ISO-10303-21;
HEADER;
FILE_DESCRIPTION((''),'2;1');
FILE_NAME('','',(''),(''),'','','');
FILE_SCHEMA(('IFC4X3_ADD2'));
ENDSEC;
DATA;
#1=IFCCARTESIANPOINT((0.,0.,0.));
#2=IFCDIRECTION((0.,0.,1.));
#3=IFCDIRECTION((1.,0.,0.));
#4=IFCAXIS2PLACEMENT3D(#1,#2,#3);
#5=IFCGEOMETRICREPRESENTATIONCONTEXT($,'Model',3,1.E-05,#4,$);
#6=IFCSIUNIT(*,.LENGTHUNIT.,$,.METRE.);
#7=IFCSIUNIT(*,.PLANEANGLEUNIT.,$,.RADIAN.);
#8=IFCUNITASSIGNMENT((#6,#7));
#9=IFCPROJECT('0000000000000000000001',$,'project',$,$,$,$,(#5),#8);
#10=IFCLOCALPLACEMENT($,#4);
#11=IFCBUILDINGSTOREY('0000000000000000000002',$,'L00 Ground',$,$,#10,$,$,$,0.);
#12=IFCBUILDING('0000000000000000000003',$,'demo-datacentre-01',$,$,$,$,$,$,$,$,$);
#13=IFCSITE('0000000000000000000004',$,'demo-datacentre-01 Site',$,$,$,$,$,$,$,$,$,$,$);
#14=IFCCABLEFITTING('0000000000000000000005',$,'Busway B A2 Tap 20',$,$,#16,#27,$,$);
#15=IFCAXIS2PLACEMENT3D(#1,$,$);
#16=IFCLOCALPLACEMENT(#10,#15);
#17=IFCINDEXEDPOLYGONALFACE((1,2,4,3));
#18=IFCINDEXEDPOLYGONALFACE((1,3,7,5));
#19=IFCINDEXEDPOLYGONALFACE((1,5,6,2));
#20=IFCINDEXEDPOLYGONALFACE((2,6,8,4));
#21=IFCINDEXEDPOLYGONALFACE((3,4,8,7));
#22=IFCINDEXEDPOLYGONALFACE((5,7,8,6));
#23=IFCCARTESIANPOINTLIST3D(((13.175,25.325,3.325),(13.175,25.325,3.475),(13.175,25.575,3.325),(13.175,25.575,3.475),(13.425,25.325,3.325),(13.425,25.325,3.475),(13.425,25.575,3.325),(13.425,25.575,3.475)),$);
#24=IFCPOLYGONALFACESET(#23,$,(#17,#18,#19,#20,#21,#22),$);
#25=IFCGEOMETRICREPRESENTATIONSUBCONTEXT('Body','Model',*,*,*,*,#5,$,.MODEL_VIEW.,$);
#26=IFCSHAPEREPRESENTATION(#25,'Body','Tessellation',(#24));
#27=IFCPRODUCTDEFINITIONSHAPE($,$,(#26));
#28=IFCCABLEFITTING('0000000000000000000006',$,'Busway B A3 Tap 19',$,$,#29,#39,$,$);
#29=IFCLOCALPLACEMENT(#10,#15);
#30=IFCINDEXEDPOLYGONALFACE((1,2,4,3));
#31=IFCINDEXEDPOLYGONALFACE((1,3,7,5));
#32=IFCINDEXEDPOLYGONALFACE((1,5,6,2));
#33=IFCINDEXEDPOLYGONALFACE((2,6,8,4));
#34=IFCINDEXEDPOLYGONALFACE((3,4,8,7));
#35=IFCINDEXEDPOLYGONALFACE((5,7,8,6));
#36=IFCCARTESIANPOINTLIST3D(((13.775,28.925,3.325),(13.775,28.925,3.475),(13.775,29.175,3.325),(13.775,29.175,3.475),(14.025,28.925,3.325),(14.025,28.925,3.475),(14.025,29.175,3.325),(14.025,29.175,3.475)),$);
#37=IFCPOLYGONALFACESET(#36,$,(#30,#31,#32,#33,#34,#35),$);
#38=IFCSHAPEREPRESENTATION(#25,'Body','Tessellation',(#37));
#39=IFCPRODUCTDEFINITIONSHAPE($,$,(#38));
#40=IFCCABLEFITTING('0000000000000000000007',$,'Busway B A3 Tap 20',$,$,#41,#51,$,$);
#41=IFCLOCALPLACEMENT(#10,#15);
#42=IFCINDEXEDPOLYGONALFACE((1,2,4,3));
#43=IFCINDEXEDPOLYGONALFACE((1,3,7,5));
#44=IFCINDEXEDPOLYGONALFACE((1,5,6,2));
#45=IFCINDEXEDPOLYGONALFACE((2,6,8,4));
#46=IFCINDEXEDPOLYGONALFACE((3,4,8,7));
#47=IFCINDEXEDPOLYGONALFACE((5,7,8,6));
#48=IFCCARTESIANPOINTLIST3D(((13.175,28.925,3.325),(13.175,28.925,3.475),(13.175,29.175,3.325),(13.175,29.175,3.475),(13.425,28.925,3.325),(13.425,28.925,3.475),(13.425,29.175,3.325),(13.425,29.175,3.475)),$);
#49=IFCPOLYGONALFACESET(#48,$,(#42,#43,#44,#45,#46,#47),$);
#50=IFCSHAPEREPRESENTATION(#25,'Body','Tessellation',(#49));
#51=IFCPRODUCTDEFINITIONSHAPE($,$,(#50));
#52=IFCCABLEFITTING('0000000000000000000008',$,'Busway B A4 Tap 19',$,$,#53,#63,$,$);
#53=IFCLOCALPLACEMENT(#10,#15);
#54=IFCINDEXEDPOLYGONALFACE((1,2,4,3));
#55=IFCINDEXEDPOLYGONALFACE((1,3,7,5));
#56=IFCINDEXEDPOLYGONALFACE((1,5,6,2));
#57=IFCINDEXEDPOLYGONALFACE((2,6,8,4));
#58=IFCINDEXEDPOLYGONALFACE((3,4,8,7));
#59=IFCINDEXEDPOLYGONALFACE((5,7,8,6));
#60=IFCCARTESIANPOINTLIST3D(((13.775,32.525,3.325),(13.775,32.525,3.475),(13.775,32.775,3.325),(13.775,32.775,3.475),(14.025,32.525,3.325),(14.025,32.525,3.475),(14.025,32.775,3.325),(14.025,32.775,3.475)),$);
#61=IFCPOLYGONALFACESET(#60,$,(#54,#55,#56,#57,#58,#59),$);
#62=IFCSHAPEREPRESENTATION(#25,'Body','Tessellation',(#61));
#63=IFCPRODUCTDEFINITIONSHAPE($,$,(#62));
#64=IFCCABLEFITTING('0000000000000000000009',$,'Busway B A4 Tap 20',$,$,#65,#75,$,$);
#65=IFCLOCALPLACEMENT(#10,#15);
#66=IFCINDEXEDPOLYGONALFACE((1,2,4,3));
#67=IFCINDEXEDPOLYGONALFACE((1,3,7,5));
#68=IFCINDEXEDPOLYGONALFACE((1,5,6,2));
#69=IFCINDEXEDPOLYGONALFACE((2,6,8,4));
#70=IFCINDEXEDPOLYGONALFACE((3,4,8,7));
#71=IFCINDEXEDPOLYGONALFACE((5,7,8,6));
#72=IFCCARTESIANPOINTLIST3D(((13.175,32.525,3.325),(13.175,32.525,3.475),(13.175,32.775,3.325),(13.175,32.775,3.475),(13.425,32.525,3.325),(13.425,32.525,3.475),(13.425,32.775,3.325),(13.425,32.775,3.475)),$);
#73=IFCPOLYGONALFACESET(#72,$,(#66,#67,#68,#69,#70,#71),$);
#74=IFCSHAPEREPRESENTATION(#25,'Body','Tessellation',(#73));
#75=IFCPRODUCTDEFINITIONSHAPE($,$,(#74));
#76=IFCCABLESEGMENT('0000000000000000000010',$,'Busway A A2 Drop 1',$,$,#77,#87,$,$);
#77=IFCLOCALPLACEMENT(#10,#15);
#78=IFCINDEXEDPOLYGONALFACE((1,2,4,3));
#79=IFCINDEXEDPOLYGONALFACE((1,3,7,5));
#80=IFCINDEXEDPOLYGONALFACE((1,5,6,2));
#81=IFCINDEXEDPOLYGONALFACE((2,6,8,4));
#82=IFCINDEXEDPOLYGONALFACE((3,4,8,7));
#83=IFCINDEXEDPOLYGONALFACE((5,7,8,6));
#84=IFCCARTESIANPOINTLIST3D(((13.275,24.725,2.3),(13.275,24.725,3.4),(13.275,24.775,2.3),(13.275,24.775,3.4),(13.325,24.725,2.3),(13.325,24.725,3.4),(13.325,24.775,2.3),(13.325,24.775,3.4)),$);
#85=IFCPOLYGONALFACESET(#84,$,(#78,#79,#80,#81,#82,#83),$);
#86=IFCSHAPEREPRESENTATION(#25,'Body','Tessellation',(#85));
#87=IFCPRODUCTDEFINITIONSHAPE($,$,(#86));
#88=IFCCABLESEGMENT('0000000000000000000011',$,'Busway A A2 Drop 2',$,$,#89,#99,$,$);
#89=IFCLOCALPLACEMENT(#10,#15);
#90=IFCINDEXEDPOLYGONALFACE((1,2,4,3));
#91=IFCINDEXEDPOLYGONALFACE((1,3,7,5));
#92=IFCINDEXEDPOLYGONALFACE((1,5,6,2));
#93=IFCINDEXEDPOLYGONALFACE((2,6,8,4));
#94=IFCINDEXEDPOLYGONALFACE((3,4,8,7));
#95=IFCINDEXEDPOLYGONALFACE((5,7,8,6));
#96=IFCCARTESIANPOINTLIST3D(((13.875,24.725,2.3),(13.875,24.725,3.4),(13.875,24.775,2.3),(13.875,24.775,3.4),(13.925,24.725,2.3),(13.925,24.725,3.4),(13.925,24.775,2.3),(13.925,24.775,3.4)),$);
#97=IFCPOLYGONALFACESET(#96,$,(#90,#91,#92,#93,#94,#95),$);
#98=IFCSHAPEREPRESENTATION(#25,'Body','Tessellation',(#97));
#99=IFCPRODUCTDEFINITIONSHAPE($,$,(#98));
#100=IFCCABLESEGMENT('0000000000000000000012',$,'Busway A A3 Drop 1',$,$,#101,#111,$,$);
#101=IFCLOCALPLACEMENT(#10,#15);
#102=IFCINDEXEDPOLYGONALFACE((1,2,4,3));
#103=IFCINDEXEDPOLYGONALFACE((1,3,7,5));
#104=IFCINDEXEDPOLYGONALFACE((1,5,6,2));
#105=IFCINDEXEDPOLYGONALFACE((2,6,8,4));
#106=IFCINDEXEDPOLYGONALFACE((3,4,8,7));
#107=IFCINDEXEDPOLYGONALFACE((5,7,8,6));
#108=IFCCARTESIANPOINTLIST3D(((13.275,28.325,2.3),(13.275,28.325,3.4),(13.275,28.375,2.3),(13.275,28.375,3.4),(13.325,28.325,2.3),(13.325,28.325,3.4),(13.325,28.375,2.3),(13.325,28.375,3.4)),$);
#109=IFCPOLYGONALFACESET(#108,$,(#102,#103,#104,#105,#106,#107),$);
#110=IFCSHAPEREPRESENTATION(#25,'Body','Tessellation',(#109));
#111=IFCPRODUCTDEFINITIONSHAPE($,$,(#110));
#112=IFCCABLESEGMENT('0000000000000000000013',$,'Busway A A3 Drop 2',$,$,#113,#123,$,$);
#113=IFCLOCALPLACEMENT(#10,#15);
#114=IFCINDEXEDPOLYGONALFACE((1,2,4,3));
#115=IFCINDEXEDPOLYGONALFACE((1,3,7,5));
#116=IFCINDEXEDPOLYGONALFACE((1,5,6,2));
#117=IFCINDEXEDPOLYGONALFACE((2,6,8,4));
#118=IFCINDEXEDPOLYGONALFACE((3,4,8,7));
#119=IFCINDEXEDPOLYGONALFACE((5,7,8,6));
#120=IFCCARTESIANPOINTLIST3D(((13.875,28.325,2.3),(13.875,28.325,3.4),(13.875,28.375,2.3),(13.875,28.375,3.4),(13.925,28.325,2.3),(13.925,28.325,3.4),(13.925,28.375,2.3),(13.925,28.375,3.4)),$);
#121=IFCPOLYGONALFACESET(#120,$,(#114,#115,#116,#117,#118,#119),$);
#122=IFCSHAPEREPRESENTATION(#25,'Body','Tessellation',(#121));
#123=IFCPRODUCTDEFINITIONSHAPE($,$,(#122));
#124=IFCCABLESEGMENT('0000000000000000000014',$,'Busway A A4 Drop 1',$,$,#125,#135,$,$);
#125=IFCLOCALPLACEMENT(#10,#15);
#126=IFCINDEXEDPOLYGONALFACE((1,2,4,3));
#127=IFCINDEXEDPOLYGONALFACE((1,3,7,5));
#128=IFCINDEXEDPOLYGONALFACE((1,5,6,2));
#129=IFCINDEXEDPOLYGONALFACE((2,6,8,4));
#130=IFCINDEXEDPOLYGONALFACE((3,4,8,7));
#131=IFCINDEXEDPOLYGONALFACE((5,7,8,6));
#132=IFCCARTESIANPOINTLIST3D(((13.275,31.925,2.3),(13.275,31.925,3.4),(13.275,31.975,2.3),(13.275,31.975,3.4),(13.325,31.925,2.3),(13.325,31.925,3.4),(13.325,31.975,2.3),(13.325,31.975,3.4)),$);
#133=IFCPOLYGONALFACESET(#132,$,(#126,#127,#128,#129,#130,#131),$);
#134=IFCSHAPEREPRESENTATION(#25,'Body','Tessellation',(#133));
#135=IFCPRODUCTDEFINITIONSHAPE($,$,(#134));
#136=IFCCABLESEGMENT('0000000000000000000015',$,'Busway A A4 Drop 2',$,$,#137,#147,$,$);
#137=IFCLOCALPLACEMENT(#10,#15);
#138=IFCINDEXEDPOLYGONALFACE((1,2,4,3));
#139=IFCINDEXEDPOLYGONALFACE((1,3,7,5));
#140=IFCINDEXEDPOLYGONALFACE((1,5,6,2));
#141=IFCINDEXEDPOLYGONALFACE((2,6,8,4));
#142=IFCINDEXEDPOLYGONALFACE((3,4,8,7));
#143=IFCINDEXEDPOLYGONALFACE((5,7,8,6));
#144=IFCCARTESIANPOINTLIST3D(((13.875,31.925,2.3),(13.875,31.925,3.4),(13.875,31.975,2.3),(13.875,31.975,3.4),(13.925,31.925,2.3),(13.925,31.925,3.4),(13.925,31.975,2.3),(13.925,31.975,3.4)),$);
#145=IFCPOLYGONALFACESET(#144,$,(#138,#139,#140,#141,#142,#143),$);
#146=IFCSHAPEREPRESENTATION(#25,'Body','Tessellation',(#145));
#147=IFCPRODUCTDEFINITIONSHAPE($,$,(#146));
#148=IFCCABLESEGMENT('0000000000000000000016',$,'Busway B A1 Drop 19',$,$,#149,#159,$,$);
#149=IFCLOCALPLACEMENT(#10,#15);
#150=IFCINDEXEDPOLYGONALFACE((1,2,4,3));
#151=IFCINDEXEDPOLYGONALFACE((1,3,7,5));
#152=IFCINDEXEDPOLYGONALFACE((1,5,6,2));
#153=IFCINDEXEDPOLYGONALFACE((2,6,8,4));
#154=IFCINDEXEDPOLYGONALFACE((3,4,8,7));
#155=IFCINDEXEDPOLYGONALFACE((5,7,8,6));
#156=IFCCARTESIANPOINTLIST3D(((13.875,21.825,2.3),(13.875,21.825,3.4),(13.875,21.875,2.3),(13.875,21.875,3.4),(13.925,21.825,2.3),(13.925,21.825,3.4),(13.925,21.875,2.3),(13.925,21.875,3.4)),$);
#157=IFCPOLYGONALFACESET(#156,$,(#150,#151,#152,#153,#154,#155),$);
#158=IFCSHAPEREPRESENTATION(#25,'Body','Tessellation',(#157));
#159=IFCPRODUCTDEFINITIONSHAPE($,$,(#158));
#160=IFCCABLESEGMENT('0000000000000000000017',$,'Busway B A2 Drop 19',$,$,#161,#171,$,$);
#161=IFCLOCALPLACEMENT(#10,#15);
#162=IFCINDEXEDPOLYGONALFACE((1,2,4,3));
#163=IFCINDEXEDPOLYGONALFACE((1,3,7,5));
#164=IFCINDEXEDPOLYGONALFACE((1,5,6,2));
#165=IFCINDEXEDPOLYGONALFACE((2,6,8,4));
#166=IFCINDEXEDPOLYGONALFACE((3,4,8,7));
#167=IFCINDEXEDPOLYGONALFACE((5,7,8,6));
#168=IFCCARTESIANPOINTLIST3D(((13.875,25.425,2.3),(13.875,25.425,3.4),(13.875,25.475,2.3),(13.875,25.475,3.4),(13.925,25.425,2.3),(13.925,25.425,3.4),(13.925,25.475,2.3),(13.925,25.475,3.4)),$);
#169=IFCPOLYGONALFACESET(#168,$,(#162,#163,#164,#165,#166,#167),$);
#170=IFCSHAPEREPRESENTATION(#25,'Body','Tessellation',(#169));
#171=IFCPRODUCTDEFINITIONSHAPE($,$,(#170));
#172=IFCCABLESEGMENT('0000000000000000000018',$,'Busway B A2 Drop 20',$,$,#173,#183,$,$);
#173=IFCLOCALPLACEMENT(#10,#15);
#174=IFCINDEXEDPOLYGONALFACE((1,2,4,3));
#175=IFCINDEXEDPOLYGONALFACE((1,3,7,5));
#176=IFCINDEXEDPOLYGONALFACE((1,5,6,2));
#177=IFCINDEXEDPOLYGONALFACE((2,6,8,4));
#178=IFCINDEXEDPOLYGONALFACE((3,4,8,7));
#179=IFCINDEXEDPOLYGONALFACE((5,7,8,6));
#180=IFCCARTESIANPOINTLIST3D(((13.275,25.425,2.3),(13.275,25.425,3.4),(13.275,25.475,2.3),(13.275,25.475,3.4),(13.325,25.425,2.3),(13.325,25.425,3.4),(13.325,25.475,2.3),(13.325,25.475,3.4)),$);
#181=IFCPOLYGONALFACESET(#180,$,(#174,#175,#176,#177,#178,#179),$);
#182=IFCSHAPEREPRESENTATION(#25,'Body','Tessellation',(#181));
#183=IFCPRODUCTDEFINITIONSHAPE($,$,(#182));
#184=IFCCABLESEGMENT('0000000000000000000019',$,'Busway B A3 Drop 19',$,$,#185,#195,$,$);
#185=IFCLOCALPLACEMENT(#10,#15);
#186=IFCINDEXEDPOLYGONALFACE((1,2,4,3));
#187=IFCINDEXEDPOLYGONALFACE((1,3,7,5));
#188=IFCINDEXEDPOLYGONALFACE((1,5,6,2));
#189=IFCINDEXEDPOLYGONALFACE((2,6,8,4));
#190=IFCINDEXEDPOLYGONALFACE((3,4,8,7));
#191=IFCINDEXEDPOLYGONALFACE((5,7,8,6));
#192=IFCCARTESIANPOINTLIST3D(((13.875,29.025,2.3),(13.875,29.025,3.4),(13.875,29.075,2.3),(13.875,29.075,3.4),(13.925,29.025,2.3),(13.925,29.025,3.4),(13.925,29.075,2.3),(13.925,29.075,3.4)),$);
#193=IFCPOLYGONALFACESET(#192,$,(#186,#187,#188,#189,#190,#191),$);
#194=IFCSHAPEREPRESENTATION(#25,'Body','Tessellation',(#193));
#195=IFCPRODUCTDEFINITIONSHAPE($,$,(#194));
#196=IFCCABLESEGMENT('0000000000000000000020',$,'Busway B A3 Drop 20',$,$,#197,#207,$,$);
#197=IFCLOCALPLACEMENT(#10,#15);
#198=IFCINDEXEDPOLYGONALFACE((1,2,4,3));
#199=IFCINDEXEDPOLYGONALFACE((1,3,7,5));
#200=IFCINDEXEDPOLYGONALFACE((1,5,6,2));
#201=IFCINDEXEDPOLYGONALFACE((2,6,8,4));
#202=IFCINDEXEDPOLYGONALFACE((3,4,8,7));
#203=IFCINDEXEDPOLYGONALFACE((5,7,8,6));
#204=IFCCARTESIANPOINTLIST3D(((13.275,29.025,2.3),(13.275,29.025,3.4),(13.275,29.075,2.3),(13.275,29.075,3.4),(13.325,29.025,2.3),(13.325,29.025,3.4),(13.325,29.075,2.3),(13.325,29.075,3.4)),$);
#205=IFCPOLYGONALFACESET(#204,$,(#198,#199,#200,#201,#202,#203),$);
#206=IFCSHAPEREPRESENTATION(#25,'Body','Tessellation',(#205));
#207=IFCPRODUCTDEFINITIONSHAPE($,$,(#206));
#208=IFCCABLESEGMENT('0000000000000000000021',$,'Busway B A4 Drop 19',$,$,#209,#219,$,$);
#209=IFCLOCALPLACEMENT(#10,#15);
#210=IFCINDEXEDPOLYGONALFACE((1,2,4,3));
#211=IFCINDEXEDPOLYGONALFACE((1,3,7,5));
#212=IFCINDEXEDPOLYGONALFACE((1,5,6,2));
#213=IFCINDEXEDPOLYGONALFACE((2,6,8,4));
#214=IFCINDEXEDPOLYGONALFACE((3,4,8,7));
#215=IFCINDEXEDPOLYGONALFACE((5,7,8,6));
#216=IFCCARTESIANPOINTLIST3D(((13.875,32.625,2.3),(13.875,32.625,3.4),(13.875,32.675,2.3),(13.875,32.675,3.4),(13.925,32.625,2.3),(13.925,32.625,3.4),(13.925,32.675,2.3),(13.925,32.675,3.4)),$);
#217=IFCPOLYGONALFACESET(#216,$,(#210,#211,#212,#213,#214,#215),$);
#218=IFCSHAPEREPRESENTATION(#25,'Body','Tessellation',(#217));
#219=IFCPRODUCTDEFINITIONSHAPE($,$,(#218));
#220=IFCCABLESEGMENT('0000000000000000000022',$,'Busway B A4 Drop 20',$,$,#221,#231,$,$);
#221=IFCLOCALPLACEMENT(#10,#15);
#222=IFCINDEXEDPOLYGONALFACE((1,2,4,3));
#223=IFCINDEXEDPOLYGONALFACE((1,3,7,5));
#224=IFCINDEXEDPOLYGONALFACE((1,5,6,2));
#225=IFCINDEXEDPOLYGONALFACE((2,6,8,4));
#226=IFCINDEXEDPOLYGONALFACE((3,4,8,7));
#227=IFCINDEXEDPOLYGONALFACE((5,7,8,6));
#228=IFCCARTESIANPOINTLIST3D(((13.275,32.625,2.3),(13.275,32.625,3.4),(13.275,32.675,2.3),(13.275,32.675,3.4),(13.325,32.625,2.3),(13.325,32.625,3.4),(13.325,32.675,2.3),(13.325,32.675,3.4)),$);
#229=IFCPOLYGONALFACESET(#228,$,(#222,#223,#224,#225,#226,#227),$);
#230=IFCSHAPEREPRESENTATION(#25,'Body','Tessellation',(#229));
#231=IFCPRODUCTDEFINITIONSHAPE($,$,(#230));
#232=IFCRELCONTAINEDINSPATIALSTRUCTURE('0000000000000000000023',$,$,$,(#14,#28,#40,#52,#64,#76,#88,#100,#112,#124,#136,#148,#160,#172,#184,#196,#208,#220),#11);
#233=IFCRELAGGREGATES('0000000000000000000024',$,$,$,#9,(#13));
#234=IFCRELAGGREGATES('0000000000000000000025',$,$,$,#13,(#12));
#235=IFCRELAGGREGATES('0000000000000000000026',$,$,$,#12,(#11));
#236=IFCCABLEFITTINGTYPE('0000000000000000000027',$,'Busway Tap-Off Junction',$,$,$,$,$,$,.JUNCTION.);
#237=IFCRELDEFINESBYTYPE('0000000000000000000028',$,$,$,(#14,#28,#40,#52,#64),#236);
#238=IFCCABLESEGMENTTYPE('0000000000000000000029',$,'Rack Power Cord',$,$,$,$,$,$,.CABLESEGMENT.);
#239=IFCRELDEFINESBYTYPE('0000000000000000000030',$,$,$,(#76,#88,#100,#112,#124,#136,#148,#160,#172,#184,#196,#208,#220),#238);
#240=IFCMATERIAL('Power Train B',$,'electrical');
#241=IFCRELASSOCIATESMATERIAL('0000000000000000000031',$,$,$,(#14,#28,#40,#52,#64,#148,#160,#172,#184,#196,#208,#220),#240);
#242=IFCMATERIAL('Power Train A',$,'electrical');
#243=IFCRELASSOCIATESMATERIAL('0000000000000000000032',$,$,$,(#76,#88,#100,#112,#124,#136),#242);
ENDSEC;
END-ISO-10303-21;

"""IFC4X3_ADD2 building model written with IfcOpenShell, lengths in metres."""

from ifc_helpers import new_model, si_unit, frame, origin_with_axes, place, context, subcontext, project, spatial, rectangle, extrude, material, type_object, element, save


model = new_model("IFC4X3_ADD2")

# Units and contexts
model_context = context("Model", 3, precision=1e-05, world=origin_with_axes())
body_context = subcontext(model_context, "Body", "Model", "MODEL_VIEW")
ifc_project = project(units=[si_unit("LENGTHUNIT", "METRE"), si_unit("PLANEANGLEUNIT", "RADIAN")], contexts=[model_context])

# Site, building, storey
site = spatial("IfcSite", under=ifc_project, Name="demo-datacentre-01 Site")
building = spatial("IfcBuilding", under=site, Name="demo-datacentre-01")
storey_placement = place(None, origin_with_axes())
storey = spatial("IfcBuildingStorey", under=building, at=storey_placement, Name="L00 Ground", Elevation=0.0)

# Shared definitions
ifc_material_1 = material(Name="Power Train A", Category="electrical")

# Shared definitions
ifc_material_2 = material(Name="Power Train B", Category="electrical")

# Cable fittings
cable_fitting_type = type_object("IfcCableFittingType", Name="Busway Tap-Off Junction", PredefinedType="JUNCTION")
for number, where, z_axis, x_axis, name in (
    (1, (13.3, 25.45, 3.325), (0.0, 0.0, 1.0), (1.0, 0.0, 0.0), "Busway B A2 Tap 20"),
    (2, (13.9, 29.05, 3.325), (0.0, 0.0, 1.0), (1.0, 0.0, 0.0), "Busway B A3 Tap 19"),
    (3, (13.3, 29.05, 3.325), (0.0, 0.0, 1.0), (1.0, 0.0, 0.0), "Busway B A3 Tap 20"),
    (4, (13.9, 32.65, 3.325), (0.0, 0.0, 1.0), (1.0, 0.0, 0.0), "Busway B A4 Tap 19"),
    (5, (13.3, 32.65, 3.325), (0.0, 0.0, 1.0), (1.0, 0.0, 0.0), "Busway B A4 Tap 20"),
):
    element("IfcCableFitting", number, at=place(storey_placement, frame(where, z_axis=z_axis, x_axis=x_axis)), inside=storey, type_object=cable_fitting_type, material=ifc_material_2, Name=name, context=body_context, shape_type="SweptSolid", body=[
        extrude(rectangle(XDim=0.25, YDim=0.25), origin_with_axes(), (0.0, 0.0, 1.0), 0.15),
    ])

# Cable segments
cable_segment_type_1 = type_object("IfcCableSegmentType", Name="Rack Power Cord", PredefinedType="CABLESEGMENT")
for number, where, z_axis, x_axis, name in (
    (6, (13.3, 24.75, 3.4), (0.0, 0.0, -1.0), (1.0, 0.0, 0.0), "Busway A A2 Drop 1"),
    (7, (13.9, 24.75, 3.4), (0.0, 0.0, -1.0), (1.0, 0.0, 0.0), "Busway A A2 Drop 2"),
    (8, (13.3, 28.35, 3.4), (0.0, 0.0, -1.0), (1.0, 0.0, 0.0), "Busway A A3 Drop 1"),
    (9, (13.9, 28.35, 3.4), (0.0, 0.0, -1.0), (1.0, 0.0, 0.0), "Busway A A3 Drop 2"),
    (10, (13.3, 31.95, 3.4), (0.0, 0.0, -1.0), (1.0, 0.0, 0.0), "Busway A A4 Drop 1"),
    (11, (13.9, 31.95, 3.4), (0.0, 0.0, -1.0), (1.0, 0.0, 0.0), "Busway A A4 Drop 2"),
):
    element("IfcCableSegment", number, at=place(storey_placement, frame(where, z_axis=z_axis, x_axis=x_axis)), inside=storey, type_object=cable_segment_type_1, material=ifc_material_1, Name=name, context=body_context, shape_type="SweptSolid", body=[
        extrude(rectangle(XDim=0.05, YDim=0.05), origin_with_axes(), (0.0, 0.0, 1.0), 1.1),
    ])
for number, where, z_axis, x_axis, name in (
    (12, (13.9, 21.85, 3.4), (0.0, 0.0, -1.0), (1.0, 0.0, 0.0), "Busway B A1 Drop 19"),
    (13, (13.9, 25.45, 3.4), (0.0, 0.0, -1.0), (1.0, 0.0, 0.0), "Busway B A2 Drop 19"),
    (14, (13.3, 25.45, 3.4), (0.0, 0.0, -1.0), (1.0, 0.0, 0.0), "Busway B A2 Drop 20"),
    (15, (13.9, 29.05, 3.4), (0.0, 0.0, -1.0), (1.0, 0.0, 0.0), "Busway B A3 Drop 19"),
    (16, (13.3, 29.05, 3.4), (0.0, 0.0, -1.0), (1.0, 0.0, 0.0), "Busway B A3 Drop 20"),
    (17, (13.9, 32.65, 3.4), (0.0, 0.0, -1.0), (1.0, 0.0, 0.0), "Busway B A4 Drop 19"),
    (18, (13.3, 32.65, 3.4), (0.0, 0.0, -1.0), (1.0, 0.0, 0.0), "Busway B A4 Drop 20"),
):
    element("IfcCableSegment", number, at=place(storey_placement, frame(where, z_axis=z_axis, x_axis=x_axis)), inside=storey, type_object=cable_segment_type_1, material=ifc_material_2, Name=name, context=body_context, shape_type="SweptSolid", body=[
        extrude(rectangle(XDim=0.05, YDim=0.05), origin_with_axes(), (0.0, 0.0, 1.0), 1.1),
    ])

save(model, "model.ifc")
